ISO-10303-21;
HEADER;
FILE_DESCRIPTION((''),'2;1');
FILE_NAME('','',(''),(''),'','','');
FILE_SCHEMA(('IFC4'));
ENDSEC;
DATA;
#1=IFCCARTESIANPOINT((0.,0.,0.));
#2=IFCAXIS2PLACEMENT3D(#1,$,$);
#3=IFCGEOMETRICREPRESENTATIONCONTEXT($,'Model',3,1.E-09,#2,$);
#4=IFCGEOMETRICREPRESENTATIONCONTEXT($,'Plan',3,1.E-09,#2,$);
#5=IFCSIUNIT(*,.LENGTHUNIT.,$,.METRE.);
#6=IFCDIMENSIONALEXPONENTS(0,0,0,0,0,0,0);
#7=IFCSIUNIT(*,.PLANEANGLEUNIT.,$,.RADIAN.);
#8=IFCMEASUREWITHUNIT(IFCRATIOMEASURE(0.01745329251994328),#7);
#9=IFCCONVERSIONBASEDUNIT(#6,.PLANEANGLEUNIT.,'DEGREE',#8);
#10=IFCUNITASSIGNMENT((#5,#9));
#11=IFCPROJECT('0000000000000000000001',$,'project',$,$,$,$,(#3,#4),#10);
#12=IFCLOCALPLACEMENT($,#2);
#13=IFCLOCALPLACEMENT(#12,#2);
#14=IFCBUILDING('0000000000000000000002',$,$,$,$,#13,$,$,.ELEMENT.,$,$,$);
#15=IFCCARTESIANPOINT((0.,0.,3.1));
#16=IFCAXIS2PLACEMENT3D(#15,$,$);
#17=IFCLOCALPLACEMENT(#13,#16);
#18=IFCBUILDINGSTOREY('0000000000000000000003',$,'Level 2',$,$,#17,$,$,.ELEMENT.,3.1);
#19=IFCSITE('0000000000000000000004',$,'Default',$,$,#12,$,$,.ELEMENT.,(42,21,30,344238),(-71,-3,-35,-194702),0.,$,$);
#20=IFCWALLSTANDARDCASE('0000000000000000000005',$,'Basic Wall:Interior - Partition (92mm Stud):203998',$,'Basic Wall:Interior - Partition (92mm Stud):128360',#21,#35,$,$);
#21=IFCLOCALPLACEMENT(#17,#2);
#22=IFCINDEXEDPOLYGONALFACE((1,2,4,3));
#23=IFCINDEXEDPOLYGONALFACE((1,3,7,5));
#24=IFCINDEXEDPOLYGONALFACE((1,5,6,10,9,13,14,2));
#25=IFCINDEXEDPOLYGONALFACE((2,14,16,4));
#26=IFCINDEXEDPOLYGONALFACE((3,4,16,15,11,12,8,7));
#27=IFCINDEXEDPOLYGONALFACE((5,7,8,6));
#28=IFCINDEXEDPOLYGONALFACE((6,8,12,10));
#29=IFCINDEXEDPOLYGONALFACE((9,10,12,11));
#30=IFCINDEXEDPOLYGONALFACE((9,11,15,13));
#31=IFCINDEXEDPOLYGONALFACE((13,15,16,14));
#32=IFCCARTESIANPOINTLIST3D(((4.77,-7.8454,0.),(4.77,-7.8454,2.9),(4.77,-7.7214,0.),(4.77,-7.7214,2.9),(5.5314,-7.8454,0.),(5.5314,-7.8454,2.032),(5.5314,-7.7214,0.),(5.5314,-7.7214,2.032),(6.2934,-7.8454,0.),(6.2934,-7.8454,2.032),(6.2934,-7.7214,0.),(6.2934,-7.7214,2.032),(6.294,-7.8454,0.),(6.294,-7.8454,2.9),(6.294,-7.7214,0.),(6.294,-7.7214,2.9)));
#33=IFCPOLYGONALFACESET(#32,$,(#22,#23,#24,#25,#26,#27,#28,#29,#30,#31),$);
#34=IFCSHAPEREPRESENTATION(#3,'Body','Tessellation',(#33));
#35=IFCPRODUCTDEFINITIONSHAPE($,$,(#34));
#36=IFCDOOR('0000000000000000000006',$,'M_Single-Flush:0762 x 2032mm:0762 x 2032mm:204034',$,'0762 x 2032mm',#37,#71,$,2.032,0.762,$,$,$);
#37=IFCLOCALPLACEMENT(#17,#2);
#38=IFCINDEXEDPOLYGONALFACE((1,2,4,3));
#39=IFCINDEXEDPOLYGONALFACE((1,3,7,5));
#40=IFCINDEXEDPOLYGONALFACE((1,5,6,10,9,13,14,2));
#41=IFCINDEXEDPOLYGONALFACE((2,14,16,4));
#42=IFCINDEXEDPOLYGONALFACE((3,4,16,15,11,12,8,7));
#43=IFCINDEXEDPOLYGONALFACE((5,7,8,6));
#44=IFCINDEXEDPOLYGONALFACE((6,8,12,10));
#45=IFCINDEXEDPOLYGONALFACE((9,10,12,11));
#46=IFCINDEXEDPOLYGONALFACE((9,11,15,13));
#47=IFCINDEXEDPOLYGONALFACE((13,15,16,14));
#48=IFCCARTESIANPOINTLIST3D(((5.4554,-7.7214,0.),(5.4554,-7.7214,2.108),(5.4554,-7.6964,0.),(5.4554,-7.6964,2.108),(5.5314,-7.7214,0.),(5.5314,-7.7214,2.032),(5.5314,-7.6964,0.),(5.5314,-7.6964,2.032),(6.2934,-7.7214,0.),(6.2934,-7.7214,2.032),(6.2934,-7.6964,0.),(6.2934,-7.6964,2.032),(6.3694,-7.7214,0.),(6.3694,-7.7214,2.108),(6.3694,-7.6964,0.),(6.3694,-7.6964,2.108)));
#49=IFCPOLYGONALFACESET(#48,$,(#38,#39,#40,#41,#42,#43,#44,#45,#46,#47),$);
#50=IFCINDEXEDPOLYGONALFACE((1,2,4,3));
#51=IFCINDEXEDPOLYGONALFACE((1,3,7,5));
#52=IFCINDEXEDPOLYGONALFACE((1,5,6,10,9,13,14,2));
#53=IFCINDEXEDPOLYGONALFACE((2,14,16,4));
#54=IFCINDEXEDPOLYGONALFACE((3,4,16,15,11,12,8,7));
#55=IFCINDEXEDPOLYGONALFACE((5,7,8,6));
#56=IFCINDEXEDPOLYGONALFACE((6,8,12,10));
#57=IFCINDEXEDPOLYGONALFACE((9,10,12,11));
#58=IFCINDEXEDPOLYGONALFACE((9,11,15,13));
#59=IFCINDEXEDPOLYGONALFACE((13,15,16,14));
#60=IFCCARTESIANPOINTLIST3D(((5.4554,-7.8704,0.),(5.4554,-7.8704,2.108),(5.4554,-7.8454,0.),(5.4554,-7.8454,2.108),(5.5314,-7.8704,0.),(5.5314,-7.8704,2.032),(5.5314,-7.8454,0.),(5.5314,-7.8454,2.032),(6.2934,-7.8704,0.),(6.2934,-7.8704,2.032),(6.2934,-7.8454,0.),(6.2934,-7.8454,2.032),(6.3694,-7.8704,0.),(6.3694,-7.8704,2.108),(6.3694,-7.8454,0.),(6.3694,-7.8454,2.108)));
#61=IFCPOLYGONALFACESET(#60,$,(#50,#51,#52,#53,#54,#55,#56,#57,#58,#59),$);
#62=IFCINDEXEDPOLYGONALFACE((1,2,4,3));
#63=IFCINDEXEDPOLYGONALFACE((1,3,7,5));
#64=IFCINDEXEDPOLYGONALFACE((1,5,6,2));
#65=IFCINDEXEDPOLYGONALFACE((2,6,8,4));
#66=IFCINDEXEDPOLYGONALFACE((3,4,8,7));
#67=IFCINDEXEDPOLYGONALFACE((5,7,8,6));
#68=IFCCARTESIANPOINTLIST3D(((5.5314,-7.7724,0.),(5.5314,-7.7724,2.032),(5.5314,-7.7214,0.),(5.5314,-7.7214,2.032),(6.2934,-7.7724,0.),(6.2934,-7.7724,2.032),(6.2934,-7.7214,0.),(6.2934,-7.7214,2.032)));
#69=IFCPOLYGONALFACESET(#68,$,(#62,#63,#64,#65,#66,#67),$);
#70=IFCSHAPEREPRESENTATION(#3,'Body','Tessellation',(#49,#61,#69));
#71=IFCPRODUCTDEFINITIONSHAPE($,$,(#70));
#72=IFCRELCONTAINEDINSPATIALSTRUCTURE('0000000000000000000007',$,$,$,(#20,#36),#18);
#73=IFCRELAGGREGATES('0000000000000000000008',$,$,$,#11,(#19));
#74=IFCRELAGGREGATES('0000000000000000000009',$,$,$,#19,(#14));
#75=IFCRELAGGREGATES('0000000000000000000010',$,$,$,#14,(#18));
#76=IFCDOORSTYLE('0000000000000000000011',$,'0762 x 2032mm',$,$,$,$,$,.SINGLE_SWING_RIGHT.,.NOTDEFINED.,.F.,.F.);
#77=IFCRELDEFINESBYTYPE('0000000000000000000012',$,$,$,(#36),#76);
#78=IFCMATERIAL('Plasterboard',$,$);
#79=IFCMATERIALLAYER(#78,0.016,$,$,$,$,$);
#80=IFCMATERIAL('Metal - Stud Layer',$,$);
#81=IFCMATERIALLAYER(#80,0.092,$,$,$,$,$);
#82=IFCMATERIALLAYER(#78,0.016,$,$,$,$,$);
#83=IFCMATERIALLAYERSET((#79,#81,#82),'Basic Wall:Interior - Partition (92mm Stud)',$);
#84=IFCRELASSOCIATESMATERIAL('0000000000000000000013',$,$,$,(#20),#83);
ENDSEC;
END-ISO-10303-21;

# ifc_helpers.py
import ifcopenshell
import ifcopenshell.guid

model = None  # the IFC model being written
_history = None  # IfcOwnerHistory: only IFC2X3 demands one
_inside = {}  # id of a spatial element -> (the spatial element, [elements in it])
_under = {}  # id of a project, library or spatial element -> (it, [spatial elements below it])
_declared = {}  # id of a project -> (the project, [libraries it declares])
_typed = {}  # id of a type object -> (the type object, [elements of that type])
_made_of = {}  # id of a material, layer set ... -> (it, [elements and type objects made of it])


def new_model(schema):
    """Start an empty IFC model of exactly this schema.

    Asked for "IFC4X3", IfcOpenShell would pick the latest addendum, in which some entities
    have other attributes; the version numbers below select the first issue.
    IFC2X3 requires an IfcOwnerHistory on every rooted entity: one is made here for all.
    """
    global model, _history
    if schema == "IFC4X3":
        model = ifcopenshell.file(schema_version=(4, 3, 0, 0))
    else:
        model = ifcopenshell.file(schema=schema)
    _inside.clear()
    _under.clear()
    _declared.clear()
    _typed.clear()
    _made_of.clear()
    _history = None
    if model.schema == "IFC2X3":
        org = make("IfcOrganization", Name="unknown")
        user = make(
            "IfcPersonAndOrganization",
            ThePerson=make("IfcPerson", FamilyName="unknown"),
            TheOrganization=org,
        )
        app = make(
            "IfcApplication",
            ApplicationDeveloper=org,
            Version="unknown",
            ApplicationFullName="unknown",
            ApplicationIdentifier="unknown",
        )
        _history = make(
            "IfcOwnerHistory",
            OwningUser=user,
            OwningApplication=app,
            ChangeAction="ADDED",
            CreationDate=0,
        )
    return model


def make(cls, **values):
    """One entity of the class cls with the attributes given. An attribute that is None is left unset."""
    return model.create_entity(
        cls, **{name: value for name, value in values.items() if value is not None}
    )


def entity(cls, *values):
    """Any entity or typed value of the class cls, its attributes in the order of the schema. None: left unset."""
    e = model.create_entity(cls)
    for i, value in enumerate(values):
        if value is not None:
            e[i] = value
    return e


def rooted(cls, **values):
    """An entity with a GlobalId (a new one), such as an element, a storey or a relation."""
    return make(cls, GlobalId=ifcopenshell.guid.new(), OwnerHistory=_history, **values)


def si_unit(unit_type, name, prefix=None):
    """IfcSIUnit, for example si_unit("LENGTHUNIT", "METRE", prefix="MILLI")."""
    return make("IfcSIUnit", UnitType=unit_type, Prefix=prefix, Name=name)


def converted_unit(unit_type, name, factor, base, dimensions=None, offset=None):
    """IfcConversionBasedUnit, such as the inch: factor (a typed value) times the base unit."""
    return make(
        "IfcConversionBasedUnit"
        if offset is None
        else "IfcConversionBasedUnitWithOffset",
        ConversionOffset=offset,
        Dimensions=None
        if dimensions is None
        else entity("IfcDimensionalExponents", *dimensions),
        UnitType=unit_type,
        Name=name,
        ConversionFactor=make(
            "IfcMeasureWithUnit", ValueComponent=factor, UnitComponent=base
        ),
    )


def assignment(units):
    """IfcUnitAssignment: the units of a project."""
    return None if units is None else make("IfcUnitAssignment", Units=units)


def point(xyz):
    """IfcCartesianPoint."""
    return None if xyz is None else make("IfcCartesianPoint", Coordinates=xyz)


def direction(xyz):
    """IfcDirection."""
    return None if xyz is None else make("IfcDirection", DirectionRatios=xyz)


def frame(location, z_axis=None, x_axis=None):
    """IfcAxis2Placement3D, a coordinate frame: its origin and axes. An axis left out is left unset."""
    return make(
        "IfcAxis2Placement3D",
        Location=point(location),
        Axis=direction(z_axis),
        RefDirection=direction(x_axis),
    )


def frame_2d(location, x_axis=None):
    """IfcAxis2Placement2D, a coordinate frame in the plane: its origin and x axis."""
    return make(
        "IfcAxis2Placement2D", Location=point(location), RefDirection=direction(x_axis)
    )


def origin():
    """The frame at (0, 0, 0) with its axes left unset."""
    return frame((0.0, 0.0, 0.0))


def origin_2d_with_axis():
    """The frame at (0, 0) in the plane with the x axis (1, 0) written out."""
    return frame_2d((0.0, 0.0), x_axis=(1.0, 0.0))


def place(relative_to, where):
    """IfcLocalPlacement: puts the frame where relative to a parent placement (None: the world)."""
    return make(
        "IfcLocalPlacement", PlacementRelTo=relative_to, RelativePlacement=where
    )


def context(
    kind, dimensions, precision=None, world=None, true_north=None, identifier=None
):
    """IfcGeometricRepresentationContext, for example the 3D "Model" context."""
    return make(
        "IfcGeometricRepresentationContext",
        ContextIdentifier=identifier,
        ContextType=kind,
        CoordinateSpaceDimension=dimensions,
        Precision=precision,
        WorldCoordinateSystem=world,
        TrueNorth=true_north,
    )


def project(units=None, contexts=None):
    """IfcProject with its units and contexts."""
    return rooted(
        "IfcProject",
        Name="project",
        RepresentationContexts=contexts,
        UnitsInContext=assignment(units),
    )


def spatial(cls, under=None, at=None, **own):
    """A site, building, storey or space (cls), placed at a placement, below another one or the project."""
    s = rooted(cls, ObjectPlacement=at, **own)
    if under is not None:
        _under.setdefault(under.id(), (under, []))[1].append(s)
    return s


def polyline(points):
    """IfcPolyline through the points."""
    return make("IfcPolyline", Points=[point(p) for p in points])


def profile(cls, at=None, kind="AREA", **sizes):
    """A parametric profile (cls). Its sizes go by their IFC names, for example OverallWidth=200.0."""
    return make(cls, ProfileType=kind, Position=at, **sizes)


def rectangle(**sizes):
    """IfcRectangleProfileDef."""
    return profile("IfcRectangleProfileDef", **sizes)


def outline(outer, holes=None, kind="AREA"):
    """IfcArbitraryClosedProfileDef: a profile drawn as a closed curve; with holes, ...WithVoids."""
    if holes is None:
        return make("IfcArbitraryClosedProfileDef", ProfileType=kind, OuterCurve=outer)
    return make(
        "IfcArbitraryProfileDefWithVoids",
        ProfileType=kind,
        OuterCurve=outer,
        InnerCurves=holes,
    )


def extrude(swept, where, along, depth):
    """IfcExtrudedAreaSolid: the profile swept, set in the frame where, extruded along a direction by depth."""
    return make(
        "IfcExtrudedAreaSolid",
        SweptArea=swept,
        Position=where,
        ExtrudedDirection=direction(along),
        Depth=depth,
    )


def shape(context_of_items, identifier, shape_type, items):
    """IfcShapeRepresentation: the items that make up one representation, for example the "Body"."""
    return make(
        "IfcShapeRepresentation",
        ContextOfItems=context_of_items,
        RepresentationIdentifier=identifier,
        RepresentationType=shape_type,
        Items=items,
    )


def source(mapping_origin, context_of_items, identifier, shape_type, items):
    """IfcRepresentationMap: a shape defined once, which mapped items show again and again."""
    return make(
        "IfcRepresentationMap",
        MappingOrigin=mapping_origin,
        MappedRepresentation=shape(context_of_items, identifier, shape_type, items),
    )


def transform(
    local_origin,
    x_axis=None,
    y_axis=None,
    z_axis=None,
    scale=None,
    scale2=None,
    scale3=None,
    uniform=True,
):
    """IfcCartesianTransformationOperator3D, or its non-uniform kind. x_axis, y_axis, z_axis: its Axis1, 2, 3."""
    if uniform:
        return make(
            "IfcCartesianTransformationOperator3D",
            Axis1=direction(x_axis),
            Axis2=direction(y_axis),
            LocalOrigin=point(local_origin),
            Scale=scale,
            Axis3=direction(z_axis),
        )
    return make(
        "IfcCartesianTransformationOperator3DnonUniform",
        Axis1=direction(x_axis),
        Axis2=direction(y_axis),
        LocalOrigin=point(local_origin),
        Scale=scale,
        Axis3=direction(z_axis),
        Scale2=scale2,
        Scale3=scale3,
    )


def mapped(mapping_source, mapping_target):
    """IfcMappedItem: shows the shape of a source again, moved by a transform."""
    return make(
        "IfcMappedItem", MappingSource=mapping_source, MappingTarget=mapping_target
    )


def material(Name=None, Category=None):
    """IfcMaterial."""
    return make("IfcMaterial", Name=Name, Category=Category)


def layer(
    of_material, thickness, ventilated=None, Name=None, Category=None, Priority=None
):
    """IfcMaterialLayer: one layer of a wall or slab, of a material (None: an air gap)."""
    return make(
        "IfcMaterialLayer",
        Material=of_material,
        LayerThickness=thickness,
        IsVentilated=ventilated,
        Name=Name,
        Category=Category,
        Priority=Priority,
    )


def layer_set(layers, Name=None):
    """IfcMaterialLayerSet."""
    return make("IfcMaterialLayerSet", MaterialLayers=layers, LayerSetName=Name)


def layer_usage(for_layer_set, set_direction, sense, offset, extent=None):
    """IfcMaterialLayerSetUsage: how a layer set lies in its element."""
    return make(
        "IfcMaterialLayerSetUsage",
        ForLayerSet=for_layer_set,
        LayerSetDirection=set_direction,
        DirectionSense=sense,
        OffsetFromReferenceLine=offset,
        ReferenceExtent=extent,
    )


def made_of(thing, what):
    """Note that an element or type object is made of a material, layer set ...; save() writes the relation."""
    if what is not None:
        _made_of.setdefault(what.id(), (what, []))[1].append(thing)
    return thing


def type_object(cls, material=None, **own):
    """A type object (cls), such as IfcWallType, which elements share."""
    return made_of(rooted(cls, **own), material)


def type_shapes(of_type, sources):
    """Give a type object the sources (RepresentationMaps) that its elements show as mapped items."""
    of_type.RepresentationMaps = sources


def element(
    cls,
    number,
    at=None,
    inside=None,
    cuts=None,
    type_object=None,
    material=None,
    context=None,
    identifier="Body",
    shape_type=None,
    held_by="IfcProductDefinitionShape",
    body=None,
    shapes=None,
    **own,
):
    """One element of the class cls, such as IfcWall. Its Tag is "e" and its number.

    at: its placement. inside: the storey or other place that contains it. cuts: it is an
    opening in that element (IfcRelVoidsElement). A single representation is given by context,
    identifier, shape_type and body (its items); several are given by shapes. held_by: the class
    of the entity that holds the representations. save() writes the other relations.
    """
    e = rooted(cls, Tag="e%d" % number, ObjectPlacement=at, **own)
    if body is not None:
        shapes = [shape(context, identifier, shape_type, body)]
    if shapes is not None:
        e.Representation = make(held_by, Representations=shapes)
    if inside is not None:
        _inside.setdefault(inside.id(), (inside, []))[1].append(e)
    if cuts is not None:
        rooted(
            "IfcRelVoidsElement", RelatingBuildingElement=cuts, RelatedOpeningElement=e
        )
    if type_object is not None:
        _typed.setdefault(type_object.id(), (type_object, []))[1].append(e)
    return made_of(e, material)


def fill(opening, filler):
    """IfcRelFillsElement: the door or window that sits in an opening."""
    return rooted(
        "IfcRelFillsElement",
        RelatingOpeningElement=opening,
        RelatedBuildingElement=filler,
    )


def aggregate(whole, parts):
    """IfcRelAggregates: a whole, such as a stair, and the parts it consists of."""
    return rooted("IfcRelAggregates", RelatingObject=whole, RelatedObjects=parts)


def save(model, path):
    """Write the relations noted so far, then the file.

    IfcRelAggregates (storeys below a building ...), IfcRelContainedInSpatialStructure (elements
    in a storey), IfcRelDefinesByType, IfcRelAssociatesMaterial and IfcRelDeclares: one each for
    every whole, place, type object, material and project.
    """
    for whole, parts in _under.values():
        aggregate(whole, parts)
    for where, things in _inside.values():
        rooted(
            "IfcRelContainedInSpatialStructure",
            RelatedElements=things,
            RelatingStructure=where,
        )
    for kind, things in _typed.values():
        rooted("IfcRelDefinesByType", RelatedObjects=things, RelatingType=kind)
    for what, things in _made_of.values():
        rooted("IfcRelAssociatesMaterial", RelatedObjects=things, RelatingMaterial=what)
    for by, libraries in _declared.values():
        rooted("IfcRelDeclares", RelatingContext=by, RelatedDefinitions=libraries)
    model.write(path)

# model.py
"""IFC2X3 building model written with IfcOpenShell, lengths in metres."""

from ifc_helpers import new_model, entity, si_unit, converted_unit, frame, frame_2d, origin, origin_2d_with_axis, place, context, project, spatial, polyline, rectangle, outline, extrude, source, transform, mapped, material, layer, layer_set, layer_usage, type_object, type_shapes, element, fill, save


model = new_model("IFC2X3")

# Units and contexts
model_context = context("Model", 3, precision=1e-09, world=origin())
plan_context = context("Plan", 3, precision=1e-09, world=origin())
ifc_project = project(units=[si_unit("LENGTHUNIT", "METRE"), converted_unit("PLANEANGLEUNIT", "DEGREE", entity("IfcRatioMeasure", 0.01745329251994328), si_unit("PLANEANGLEUNIT", "RADIAN"), dimensions=[0, 0, 0, 0, 0, 0, 0])], contexts=[model_context, plan_context])

# Site, building, storey
site_placement = place(None, origin())
site = spatial("IfcSite", under=ifc_project, at=site_placement, Name="Default", CompositionType="ELEMENT", RefLatitude=(42, 21, 30, 344238), RefLongitude=(-71, -3, -35, -194702), RefElevation=0.0)
building_placement = place(site_placement, origin())
building = spatial("IfcBuilding", under=site, at=building_placement, CompositionType="ELEMENT")
storey_placement = place(building_placement, frame((0.0, 0.0, 3.1)))
storey = spatial("IfcBuildingStorey", under=building, at=storey_placement, Name="Level 2", CompositionType="ELEMENT", Elevation=3.1)

# Shared definitions
ifc_material_1 = material(Name="Plasterboard")
ifc_material_2 = material(Name="Metal - Stud Layer")
ifc_layer_1 = layer(ifc_material_1, 0.016)
ifc_layer_2 = layer(ifc_material_2, 0.092)
ifc_layer_3 = layer(ifc_material_1, 0.016)
ifc_layer_set_1 = layer_set([ifc_layer_1, ifc_layer_2, ifc_layer_3], Name="Basic Wall:Interior - Partition (92mm Stud)")

# Wall, opening, door
door_style = type_object("IfcDoorStyle", Name="0762 x 2032mm", ConstructionType="NOTDEFINED", OperationType="SINGLE_SWING_RIGHT", ParameterTakesPrecedence=False, Sizeable=False)
shared_shape = source(origin(), model_context, "Body", "SweptSolid", [
    extrude(outline(polyline([(-0.457, -1.073), (0.457, -1.073), (0.457, 1.035), (0.381, 1.035), (0.381, -0.997), (-0.381, -0.997), (-0.381, 1.035), (-0.457, 1.035), (-0.457, -1.073)])), frame((0.381, 0.124, 1.035), z_axis=(0.0, 1.0, 0.0), x_axis=(1.0, 0.0, 0.0)), (0.0, 0.0, 1.0), 0.025),
    extrude(outline(polyline([(-1.073, -0.457), (1.035, -0.457), (1.035, -0.381), (-0.997, -0.381), (-0.997, 0.381), (1.035, 0.381), (1.035, 0.457), (-1.073, 0.457), (-1.073, -0.457)])), frame((0.381, -0.025, 1.035), z_axis=(0.0, 1.0, 0.0), x_axis=(0.0, 0.0, -1.0)), (0.0, 0.0, 1.0), 0.025),
    extrude(rectangle(XDim=0.051, YDim=0.762, at=origin_2d_with_axis()), frame((0.381, 0.0985, 0.0), z_axis=(0.0, 0.0, 1.0), x_axis=(0.0, 1.0, 0.0)), (0.0, 0.0, 1.0), 2.032),
])
type_shapes(door_style, [shared_shape])
ifc_layer_usage_1 = layer_usage(ifc_layer_set_1, "AXIS2", "POSITIVE", -0.062)
wall_1_placement = place(storey_placement, frame((4.77, -7.7834, 0.0)))
wall_1 = element("IfcWallStandardCase", 1, at=wall_1_placement, inside=storey, material=ifc_layer_usage_1, Name="Basic Wall:Interior - Partition (92mm Stud):203998", ObjectType="Basic Wall:Interior - Partition (92mm Stud):128360", context=model_context, shape_type="SweptSolid", body=[
    extrude(rectangle(XDim=1.524, YDim=0.124, at=frame_2d((0.762, 0.0), x_axis=(-1.0, 0.0))), origin(), (0.0, 0.0, 1.0), 2.9),
])
opening_1_placement = place(wall_1_placement, frame((0.7614, -0.062, 0.0)))
opening_1 = element("IfcOpeningElement", 2, at=opening_1_placement, cuts=wall_1, ObjectType="Opening", context=model_context, shape_type="SweptSolid", body=[
    extrude(rectangle(XDim=0.762, YDim=2.032, at=frame_2d((1.016, 0.381), x_axis=(0.0, 1.0))), frame((0.0, 0.0, 0.0), z_axis=(0.0, 1.0, 0.0), x_axis=(0.0, 0.0, 1.0)), (0.0, 0.0, 1.0), 0.124),
])
door_1_placement = place(opening_1_placement, origin())
door_1 = element("IfcDoor", 3, at=door_1_placement, inside=storey, type_object=door_style, Name="M_Single-Flush:0762 x 2032mm:0762 x 2032mm:204034", ObjectType="0762 x 2032mm", OverallHeight=2.032, OverallWidth=0.762, context=model_context, shape_type="MappedRepresentation", body=[
    mapped(shared_shape, transform((0.0, 0.0, 0.0), scale=1.0)),
])
fill(opening_1, door_1)

save(model, "model.ifc")
